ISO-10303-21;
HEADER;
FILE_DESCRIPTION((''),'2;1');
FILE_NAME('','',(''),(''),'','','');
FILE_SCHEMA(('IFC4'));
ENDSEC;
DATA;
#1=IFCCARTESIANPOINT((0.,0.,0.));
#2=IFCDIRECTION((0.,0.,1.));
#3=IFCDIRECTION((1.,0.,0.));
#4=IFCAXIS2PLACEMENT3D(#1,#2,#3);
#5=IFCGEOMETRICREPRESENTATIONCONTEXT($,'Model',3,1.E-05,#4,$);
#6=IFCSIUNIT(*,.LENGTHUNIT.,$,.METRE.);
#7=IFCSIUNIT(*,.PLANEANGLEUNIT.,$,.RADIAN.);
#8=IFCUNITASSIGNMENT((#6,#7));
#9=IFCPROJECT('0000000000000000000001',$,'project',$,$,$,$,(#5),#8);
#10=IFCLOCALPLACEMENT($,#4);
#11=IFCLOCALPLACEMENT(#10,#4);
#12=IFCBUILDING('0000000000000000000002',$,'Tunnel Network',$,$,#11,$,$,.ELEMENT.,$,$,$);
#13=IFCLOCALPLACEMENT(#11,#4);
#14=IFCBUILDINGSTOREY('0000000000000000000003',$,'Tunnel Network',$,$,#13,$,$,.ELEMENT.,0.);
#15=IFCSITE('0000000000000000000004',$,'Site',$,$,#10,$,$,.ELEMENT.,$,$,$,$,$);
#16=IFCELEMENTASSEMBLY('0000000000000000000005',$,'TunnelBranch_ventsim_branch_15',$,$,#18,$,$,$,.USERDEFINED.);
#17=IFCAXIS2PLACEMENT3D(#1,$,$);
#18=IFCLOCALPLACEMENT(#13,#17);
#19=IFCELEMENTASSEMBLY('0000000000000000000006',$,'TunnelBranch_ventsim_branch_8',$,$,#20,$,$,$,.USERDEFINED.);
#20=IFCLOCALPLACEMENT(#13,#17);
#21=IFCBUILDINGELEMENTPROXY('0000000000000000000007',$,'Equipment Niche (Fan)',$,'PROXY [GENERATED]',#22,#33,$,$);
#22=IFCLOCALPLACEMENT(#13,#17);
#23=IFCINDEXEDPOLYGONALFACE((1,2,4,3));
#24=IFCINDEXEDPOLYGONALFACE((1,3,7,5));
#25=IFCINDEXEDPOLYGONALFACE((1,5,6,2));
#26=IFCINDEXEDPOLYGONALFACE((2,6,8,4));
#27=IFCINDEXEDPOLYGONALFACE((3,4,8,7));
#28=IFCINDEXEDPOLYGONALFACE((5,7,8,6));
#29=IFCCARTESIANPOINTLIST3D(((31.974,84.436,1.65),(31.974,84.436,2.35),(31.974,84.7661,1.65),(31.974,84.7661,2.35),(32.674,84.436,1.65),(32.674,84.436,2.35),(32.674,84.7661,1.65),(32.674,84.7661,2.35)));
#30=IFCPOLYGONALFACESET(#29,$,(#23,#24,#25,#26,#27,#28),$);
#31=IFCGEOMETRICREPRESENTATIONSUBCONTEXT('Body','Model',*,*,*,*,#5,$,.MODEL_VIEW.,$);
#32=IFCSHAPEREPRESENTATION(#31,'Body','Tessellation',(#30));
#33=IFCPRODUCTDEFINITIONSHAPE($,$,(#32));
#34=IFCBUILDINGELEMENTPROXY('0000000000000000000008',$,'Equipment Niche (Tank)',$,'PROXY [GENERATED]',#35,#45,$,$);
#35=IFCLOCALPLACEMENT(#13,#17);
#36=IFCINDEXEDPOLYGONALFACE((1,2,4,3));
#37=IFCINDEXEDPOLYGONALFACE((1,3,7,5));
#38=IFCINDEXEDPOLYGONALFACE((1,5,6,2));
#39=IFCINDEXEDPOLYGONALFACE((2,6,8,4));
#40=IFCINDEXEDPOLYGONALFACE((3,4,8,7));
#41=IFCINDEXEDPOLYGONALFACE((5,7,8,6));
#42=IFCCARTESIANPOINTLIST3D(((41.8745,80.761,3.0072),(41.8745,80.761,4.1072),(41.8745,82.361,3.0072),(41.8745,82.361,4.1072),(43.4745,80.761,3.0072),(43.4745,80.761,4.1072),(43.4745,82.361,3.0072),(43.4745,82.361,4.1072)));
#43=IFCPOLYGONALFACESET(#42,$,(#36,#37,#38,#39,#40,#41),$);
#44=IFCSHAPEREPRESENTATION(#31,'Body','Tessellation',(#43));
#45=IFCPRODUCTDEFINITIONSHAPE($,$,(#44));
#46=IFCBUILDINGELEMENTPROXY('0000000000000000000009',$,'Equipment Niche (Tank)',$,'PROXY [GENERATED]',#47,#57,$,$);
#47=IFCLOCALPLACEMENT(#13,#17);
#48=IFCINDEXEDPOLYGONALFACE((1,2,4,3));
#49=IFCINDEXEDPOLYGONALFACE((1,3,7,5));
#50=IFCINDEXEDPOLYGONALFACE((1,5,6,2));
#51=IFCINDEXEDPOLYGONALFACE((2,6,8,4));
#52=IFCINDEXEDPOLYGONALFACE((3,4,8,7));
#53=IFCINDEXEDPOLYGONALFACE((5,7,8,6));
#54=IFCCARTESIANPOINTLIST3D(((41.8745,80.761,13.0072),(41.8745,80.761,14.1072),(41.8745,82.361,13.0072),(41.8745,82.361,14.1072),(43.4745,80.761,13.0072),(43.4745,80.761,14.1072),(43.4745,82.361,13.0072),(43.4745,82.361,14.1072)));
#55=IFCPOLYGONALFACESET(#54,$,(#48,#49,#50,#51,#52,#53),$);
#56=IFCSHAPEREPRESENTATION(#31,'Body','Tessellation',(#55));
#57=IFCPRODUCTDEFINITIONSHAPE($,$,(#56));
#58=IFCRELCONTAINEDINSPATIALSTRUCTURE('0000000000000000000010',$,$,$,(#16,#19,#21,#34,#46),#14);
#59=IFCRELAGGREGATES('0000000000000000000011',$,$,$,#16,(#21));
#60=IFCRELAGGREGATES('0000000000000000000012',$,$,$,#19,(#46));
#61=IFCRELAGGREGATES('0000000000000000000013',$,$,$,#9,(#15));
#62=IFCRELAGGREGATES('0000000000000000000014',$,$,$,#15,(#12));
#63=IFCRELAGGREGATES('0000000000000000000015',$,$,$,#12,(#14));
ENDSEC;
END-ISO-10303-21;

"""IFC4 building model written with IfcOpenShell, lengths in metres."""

from ifc_helpers import new_model, si_unit, frame, origin_with_axes, origin_2d_with_axis, place, context, subcontext, project, spatial, rectangle, extrude, element, aggregate, save


model = new_model("IFC4")

# Units and contexts
model_context = context("Model", 3, precision=1e-05, world=origin_with_axes())
body_context = subcontext(model_context, "Body", "Model", "MODEL_VIEW")
ifc_project = project(units=[si_unit("LENGTHUNIT", "METRE"), si_unit("PLANEANGLEUNIT", "RADIAN")], contexts=[model_context])

# Site, building, storey
site_placement = place(None, origin_with_axes())
site = spatial("IfcSite", under=ifc_project, at=site_placement, Name="Site", CompositionType="ELEMENT")
building_placement = place(site_placement, origin_with_axes())
building = spatial("IfcBuilding", under=site, at=building_placement, Name="Tunnel Network", CompositionType="ELEMENT")
storey_placement = place(building_placement, origin_with_axes())
storey = spatial("IfcBuildingStorey", under=building, at=storey_placement, Name="Tunnel Network", CompositionType="ELEMENT", Elevation=0.0)

# Element assembly
assembly_1_placement = place(storey_placement, frame((32.324, 84.436, 2.0), z_axis=(0.0, 1.0, 0.0), x_axis=(-1.0, 0.0, 0.0)))
assembly_1 = element("IfcElementAssembly", 1, at=assembly_1_placement, inside=storey, Name="TunnelBranch_ventsim_branch_15", PredefinedType="USERDEFINED")

# Element assembly
assembly_2_placement = place(storey_placement, frame((47.6745, 80.761, 43.5572), z_axis=(0.0, 1.0, 0.0), x_axis=(-1.0, 0.0, 0.0)))
assembly_2 = element("IfcElementAssembly", 2, at=assembly_2_placement, inside=storey, Name="TunnelBranch_ventsim_branch_8", PredefinedType="USERDEFINED")

# Building element proxies
proxy_1_placement = place(storey_placement, frame((32.324, 84.436, 2.0), z_axis=(0.0, 1.0, 0.0), x_axis=(-1.0, 0.0, 0.0)))
proxy_1 = element("IfcBuildingElementProxy", 3, at=proxy_1_placement, inside=storey, Name="Equipment Niche (Fan)", ObjectType="PROXY [GENERATED]", context=body_context, shape_type="SweptSolid", body=[
    extrude(rectangle(XDim=0.7, YDim=0.7, at=origin_2d_with_axis()), origin_with_axes(), (0.0, 0.0, 1.0), 0.3301),
])
aggregate(assembly_1, [proxy_1])
proxy_2_placement = place(storey_placement, frame((42.6745, 80.761, 3.5572), z_axis=(0.0, 1.0, 0.0), x_axis=(-1.0, 0.0, 0.0)))
element("IfcBuildingElementProxy", 4, at=proxy_2_placement, inside=storey, Name="Equipment Niche (Tank)", ObjectType="PROXY [GENERATED]", context=body_context, shape_type="SweptSolid", body=[
    extrude(rectangle(XDim=1.6, YDim=1.1, at=origin_2d_with_axis()), origin_with_axes(), (0.0, 0.0, 1.0), 1.6),
])
proxy_3_placement = place(storey_placement, frame((42.6745, 80.761, 13.5572), z_axis=(0.0, 1.0, 0.0), x_axis=(-1.0, 0.0, 0.0)))
proxy_3 = element("IfcBuildingElementProxy", 5, at=proxy_3_placement, inside=storey, Name="Equipment Niche (Tank)", ObjectType="PROXY [GENERATED]", context=body_context, shape_type="SweptSolid", body=[
    extrude(rectangle(XDim=1.6, YDim=1.1, at=origin_2d_with_axis()), origin_with_axes(), (0.0, 0.0, 1.0), 1.6),
])
aggregate(assembly_2, [proxy_3])

save(model, "model.ifc")
